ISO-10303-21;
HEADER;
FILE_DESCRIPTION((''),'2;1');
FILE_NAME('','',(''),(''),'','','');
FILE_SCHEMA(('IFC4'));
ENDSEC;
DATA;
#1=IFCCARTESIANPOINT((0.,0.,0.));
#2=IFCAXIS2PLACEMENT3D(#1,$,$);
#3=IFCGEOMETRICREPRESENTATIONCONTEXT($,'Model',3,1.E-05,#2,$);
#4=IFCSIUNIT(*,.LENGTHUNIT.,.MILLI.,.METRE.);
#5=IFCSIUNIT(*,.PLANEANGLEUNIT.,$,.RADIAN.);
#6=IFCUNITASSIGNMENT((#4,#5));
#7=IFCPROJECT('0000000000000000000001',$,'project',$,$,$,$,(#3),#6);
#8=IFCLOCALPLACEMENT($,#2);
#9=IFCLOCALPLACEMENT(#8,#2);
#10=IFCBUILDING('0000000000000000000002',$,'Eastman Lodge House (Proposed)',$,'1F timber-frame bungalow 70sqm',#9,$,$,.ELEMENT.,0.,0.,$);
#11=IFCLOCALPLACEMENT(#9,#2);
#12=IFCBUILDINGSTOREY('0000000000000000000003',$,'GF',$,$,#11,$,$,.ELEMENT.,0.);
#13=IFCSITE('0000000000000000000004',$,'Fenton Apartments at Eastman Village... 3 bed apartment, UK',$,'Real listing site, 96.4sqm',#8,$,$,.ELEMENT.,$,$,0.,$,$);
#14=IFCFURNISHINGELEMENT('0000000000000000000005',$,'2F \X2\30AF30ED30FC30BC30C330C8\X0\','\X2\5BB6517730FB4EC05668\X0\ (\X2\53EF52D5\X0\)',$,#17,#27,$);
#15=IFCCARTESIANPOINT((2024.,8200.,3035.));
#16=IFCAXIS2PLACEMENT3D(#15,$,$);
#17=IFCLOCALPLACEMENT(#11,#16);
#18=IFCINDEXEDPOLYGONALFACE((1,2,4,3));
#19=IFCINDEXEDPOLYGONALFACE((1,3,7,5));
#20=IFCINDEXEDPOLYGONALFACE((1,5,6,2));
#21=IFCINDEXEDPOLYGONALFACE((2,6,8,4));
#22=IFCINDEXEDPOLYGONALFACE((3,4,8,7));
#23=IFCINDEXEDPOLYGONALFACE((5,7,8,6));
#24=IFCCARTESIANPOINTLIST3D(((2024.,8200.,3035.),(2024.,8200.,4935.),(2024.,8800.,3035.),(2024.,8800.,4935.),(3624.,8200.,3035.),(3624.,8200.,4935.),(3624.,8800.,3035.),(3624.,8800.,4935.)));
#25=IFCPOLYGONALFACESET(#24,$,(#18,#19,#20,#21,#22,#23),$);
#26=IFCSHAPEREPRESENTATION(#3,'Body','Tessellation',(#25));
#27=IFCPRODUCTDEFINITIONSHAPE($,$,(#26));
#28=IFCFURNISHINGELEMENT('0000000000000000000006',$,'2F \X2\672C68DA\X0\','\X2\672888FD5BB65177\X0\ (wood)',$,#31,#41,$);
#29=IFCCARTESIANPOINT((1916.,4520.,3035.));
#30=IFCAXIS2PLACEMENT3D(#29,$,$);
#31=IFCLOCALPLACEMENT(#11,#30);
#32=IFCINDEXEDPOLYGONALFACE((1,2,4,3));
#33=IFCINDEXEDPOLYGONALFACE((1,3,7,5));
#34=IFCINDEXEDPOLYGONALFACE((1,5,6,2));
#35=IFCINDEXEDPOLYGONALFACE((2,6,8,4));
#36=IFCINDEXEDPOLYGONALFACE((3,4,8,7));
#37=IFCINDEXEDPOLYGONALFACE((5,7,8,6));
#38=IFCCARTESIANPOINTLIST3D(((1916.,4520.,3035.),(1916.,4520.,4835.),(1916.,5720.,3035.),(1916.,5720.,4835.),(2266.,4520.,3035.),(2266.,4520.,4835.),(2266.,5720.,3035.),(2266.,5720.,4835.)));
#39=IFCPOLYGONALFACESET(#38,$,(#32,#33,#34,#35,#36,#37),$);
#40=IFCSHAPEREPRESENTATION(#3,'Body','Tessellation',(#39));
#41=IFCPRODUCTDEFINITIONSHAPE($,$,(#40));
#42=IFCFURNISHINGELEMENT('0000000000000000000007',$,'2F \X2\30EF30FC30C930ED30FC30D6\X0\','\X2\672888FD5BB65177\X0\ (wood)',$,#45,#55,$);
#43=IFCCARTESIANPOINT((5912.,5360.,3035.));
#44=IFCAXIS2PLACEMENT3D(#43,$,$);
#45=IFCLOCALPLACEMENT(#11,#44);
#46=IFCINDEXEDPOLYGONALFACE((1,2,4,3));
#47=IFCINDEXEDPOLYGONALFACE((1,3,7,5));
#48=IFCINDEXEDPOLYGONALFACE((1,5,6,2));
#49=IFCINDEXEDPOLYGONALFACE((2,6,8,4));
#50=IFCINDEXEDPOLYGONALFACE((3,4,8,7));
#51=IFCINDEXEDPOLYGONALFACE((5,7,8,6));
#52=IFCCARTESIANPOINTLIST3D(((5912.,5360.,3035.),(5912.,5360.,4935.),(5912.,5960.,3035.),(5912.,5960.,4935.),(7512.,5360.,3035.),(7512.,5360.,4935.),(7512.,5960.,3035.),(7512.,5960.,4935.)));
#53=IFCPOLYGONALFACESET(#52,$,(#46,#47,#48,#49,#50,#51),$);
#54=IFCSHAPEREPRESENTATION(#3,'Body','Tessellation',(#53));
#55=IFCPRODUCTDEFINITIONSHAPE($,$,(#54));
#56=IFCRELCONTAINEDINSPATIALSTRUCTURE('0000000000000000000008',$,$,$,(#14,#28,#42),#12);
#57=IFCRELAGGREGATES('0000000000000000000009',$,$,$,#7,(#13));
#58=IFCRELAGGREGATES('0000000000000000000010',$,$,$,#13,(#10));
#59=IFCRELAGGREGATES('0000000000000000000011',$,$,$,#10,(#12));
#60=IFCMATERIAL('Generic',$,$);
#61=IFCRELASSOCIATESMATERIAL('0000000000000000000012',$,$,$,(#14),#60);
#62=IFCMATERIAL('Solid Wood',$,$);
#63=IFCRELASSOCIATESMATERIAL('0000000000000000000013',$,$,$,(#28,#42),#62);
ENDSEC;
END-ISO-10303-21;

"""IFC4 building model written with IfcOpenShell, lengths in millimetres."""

from ifc_helpers import new_model, si_unit, frame, frame_2d, origin, place, context, project, spatial, rectangle, extrude, material, element, save


model = new_model("IFC4")

# Units and contexts
model_context = context("Model", 3, precision=1e-05, world=origin())
ifc_project = project(units=[si_unit("LENGTHUNIT", "METRE", prefix="MILLI"), si_unit("PLANEANGLEUNIT", "RADIAN")], contexts=[model_context])

# Site, building, storey
site_placement = place(None, origin())
site = spatial("IfcSite", under=ifc_project, at=site_placement, Name="Fenton Apartments at Eastman Village... 3 bed apartment, UK", ObjectType="Real listing site, 96.4sqm", CompositionType="ELEMENT", RefElevation=0.0)
building_placement = place(site_placement, origin())
building = spatial("IfcBuilding", under=site, at=building_placement, Name="Eastman Lodge House (Proposed)", ObjectType="1F timber-frame bungalow 70sqm", CompositionType="ELEMENT", ElevationOfRefHeight=0.0, ElevationOfTerrain=0.0)
storey_placement = place(building_placement, origin())
storey = spatial("IfcBuildingStorey", under=building, at=storey_placement, Name="GF", CompositionType="ELEMENT", Elevation=0.0)

# Shared definitions
ifc_material_1 = material(Name="Solid Wood")

# Shared definitions
ifc_material_2 = material(Name="Generic")

# Furnishing elements
furnishing_1_placement = place(storey_placement, frame((2024.0, 8200.0, 3035.0)))
element("IfcFurnishingElement", 1, at=furnishing_1_placement, inside=storey, material=ifc_material_2, Name="2F クローゼット", Description="家具・什器 (可動)", context=model_context, shape_type="SweptSolid", body=[
    extrude(rectangle(XDim=1600.0, YDim=600.0, at=frame_2d((800.0, 300.0))), frame((2024.0, 8200.0, 3035.0)), (0.0, 0.0, 1.0), 1900.0),
])
furnishing_2_placement = place(storey_placement, frame((1916.0, 4520.0, 3035.0)))
element("IfcFurnishingElement", 2, at=furnishing_2_placement, inside=storey, material=ifc_material_1, Name="2F 本棚", Description="木製家具 (wood)", context=model_context, shape_type="SweptSolid", body=[
    extrude(rectangle(XDim=350.0, YDim=1200.0, at=frame_2d((175.0, 600.0))), frame((1916.0, 4520.0, 3035.0)), (0.0, 0.0, 1.0), 1800.0),
])
furnishing_3_placement = place(storey_placement, frame((5912.0, 5360.0, 3035.0)))
element("IfcFurnishingElement", 3, at=furnishing_3_placement, inside=storey, material=ifc_material_1, Name="2F ワードローブ", Description="木製家具 (wood)", context=model_context, shape_type="SweptSolid", body=[
    extrude(rectangle(XDim=1600.0, YDim=600.0, at=frame_2d((800.0, 300.0))), frame((5912.0, 5360.0, 3035.0)), (0.0, 0.0, 1.0), 1900.0),
])

save(model, "model.ifc")
